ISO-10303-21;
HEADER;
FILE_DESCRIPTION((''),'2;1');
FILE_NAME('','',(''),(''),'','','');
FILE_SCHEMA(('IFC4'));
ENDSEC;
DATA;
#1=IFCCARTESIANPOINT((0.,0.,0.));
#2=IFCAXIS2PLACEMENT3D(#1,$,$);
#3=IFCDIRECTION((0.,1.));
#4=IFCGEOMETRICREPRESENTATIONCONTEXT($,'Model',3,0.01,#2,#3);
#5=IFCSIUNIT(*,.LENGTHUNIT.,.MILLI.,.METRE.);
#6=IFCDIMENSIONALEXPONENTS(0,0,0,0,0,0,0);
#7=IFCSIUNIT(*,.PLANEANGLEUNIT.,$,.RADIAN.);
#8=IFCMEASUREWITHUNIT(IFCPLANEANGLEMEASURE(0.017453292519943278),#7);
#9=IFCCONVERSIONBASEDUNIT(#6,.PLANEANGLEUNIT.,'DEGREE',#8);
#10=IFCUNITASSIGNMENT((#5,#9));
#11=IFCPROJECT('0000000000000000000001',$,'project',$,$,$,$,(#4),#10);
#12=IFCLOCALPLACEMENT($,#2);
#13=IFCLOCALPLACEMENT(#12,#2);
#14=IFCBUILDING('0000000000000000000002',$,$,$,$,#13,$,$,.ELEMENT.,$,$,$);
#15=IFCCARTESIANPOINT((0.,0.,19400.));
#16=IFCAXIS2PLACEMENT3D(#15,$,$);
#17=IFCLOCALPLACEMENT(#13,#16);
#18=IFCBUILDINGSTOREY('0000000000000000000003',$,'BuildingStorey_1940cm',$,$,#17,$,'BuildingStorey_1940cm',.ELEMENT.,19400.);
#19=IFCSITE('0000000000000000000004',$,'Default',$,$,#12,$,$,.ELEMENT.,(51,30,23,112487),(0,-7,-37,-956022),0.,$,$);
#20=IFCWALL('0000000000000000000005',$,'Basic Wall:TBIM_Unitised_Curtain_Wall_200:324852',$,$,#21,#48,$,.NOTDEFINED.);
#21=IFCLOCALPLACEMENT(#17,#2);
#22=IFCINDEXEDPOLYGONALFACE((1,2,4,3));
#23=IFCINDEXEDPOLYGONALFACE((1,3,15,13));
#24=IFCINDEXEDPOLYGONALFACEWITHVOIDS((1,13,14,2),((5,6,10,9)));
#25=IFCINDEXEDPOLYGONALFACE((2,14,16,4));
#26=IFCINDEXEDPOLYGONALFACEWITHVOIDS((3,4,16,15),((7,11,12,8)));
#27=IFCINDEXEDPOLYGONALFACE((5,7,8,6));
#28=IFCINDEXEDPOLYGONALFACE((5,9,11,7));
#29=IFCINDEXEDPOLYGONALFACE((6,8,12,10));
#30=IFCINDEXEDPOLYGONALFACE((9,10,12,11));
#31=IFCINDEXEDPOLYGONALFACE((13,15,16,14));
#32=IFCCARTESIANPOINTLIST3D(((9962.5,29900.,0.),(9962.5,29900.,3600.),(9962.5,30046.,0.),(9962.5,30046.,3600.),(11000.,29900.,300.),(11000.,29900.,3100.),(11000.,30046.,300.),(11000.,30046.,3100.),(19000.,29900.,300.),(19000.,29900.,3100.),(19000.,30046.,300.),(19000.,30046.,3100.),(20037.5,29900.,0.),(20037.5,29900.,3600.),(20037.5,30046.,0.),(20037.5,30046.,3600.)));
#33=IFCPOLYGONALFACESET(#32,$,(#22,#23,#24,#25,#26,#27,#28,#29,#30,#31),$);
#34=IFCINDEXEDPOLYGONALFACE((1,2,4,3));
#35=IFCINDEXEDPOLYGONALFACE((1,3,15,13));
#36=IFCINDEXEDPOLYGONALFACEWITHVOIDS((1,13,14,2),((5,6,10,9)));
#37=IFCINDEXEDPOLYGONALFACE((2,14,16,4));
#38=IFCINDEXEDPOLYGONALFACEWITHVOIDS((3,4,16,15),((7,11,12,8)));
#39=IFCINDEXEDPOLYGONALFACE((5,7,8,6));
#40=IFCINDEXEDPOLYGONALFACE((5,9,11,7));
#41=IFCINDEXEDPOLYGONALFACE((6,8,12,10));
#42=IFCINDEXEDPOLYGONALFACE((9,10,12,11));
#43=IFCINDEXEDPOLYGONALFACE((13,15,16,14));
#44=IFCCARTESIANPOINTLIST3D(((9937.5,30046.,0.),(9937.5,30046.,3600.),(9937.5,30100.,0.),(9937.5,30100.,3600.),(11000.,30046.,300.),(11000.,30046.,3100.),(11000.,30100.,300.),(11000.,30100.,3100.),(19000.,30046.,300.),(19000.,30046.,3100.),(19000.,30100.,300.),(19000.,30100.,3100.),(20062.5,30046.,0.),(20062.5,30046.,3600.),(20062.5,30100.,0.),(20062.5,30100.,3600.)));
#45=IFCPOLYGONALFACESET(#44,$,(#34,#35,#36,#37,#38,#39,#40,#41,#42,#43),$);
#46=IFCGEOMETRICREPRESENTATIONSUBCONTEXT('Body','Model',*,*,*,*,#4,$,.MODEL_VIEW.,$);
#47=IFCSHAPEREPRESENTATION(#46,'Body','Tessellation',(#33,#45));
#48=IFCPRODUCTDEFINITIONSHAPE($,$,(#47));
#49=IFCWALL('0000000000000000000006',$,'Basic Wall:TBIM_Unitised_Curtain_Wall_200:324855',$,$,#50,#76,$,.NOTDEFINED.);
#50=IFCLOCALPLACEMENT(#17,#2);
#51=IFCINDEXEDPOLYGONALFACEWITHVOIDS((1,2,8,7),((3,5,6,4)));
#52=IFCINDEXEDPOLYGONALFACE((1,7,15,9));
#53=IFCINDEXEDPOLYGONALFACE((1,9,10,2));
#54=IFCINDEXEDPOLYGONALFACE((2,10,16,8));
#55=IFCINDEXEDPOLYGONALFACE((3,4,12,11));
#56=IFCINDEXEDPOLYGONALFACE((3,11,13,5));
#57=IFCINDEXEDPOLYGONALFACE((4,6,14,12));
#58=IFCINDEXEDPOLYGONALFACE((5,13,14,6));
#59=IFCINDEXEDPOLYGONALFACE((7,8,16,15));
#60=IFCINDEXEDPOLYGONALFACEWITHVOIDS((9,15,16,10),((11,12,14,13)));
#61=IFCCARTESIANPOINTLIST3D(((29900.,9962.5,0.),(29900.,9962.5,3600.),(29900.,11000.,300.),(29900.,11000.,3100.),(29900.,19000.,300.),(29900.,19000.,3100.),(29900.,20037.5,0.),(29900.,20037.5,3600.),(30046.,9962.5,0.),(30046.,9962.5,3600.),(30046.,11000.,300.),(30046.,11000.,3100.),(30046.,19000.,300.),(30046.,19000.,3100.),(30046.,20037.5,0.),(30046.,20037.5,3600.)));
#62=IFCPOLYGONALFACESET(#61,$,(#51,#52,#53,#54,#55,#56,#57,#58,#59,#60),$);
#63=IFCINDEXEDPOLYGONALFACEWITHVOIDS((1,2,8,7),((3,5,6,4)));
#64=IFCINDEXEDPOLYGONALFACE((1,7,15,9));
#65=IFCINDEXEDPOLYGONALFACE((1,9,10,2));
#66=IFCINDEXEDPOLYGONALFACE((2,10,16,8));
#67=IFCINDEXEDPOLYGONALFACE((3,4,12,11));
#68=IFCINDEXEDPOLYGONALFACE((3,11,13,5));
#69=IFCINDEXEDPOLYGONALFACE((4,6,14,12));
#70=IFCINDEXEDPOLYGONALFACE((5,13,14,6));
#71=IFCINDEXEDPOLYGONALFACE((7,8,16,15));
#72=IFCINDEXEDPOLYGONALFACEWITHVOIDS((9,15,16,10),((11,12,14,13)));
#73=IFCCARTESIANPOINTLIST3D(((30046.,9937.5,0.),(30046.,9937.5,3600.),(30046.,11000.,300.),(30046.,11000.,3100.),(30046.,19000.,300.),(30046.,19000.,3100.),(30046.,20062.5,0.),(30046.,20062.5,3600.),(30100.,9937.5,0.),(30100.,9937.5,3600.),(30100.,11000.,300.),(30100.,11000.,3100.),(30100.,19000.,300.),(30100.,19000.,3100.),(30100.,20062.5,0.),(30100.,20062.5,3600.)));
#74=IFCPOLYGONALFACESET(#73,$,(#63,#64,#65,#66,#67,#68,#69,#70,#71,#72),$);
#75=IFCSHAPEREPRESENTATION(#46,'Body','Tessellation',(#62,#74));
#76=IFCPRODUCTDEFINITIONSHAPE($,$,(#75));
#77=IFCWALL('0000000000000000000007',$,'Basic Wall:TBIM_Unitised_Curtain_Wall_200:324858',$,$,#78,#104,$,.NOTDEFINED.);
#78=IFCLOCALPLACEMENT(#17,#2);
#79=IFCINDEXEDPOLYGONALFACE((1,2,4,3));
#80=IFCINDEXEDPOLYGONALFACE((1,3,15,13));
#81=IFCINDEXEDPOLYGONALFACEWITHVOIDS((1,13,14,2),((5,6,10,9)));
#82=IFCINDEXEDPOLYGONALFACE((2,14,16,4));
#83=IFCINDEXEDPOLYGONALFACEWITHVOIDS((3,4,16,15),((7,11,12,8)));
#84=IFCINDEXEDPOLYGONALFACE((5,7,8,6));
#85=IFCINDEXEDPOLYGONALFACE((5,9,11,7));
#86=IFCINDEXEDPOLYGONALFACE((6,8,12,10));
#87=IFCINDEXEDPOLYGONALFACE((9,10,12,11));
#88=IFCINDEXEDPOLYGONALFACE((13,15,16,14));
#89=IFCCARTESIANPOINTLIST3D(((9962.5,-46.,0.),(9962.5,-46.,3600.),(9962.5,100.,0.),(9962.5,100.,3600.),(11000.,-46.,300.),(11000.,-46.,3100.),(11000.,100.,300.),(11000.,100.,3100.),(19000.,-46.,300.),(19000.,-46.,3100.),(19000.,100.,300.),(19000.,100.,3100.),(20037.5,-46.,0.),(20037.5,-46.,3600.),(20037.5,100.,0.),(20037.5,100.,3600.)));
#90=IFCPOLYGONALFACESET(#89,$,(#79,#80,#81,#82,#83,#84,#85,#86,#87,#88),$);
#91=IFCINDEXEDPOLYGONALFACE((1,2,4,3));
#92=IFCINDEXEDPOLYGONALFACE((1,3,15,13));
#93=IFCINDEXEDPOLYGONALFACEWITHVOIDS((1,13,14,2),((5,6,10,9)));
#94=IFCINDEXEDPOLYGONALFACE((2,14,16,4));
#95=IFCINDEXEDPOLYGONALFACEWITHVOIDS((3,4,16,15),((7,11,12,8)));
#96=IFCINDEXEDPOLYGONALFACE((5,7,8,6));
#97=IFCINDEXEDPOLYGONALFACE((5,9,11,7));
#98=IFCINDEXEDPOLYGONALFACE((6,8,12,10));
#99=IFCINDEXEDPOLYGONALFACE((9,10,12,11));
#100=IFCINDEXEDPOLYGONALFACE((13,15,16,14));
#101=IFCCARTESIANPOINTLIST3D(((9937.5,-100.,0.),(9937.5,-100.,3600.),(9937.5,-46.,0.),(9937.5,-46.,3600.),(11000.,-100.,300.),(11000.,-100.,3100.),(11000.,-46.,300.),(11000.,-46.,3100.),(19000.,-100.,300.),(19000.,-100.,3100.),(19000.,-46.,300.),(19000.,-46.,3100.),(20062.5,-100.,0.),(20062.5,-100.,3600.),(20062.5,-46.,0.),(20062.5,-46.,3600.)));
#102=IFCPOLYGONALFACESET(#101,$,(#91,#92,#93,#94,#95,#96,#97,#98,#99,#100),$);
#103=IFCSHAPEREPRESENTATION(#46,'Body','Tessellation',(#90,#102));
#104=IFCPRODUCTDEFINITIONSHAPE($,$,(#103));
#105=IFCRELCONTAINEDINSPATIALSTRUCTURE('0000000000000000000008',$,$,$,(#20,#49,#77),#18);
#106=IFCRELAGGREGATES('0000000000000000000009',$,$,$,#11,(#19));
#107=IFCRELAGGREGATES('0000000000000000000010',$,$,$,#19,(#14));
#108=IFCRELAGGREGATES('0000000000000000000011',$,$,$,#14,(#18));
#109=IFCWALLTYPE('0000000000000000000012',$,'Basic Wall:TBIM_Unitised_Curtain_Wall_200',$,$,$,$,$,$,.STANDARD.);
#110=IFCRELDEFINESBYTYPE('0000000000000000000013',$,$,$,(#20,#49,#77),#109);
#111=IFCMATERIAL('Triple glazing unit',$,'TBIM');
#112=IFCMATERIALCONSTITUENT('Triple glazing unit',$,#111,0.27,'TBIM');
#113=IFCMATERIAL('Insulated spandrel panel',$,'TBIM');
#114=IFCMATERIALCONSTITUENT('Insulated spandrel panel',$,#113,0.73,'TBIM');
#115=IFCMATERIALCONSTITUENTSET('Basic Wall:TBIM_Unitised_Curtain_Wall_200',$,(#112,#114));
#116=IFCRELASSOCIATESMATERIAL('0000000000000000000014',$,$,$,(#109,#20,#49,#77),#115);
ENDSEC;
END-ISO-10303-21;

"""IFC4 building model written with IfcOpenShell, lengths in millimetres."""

from ifc_helpers import new_model, entity, si_unit, converted_unit, direction, frame, origin, place, context, subcontext, project, spatial, indexed_curve, outline, extrude, material, constituent, constituent_set, type_object, element, save


model = new_model("IFC4")

# Units and contexts
model_context = context("Model", 3, precision=0.01, world=origin(), true_north=direction((0.0, 1.0)))
body_context = subcontext(model_context, "Body", "Model", "MODEL_VIEW")
ifc_project = project(units=[si_unit("LENGTHUNIT", "METRE", prefix="MILLI"), converted_unit("PLANEANGLEUNIT", "DEGREE", entity("IfcPlaneAngleMeasure", 0.017453292519943278), si_unit("PLANEANGLEUNIT", "RADIAN"), dimensions=[0, 0, 0, 0, 0, 0, 0])], contexts=[model_context])

# Site, building, storey
site_placement = place(None, origin())
site = spatial("IfcSite", under=ifc_project, at=site_placement, Name="Default", CompositionType="ELEMENT", RefLatitude=(51, 30, 23, 112487), RefLongitude=(0, -7, -37, -956022), RefElevation=0.0)
building_placement = place(site_placement, origin())
building = spatial("IfcBuilding", under=site, at=building_placement, CompositionType="ELEMENT")
storey_placement = place(building_placement, frame((0.0, 0.0, 19400.0)))
storey = spatial("IfcBuildingStorey", under=building, at=storey_placement, Name="BuildingStorey_1940cm", LongName="BuildingStorey_1940cm", CompositionType="ELEMENT", Elevation=19400.0)

# Walls, openings
ifc_material_1 = material(Name="Triple glazing unit", Category="TBIM")
ifc_constituent_1 = constituent(ifc_material_1, Name="Triple glazing unit", Category="TBIM", fraction=0.27)
ifc_material_2 = material(Name="Insulated spandrel panel", Category="TBIM")
ifc_constituent_2 = constituent(ifc_material_2, Name="Insulated spandrel panel", Category="TBIM", fraction=0.73)
ifc_constituent_set_1 = constituent_set(constituents=[ifc_constituent_1, ifc_constituent_2], Name="Basic Wall:TBIM_Unitised_Curtain_Wall_200")
wall_type_1 = type_object("IfcWallType", Name="Basic Wall:TBIM_Unitised_Curtain_Wall_200", PredefinedType="STANDARD", material=ifc_constituent_set_1)
wall_1_placement = place(storey_placement, frame((9937.5, 30000.0, 0.0)))
wall_1 = element("IfcWall", 1, at=wall_1_placement, inside=storey, type_object=wall_type_1, material=ifc_constituent_set_1, Name="Basic Wall:TBIM_Unitised_Curtain_Wall_200:324852", PredefinedType="NOTDEFINED", context=body_context, shape_type="SweptSolid", body=[
    extrude(outline(indexed_curve([(-1800.0, -5037.5), (1800.0, -5037.5), (1800.0, -4937.5), (1800.0, 4937.5), (1800.0, 5037.5), (-1800.0, 5037.5), (-1800.0, 4937.5), (-1800.0, -4937.5), (-1800.0, -5037.5)], self_intersect=False), holes=[indexed_curve([(1300.0, -4000.0), (-1500.0, -4000.0), (-1500.0, 4000.0), (1300.0, 4000.0), (1300.0, -4000.0)], self_intersect=False)]), frame((5062.5, -100.0, 1800.0), z_axis=(0.0, 1.0, 0.0), x_axis=(0.0, 0.0, 1.0)), (0.0, 0.0, 1.0), 146.0),
    extrude(outline(indexed_curve([(-1800.0, -5062.5), (1800.0, -5062.5), (1800.0, 5062.5), (-1800.0, 5062.5), (-1800.0, -5062.5)], self_intersect=False), holes=[indexed_curve([(-1500.0, -4000.0), (-1500.0, 4000.0), (1300.0, 4000.0), (1300.0, -4000.0), (-1500.0, -4000.0)], self_intersect=False)]), frame((5062.5, 46.0, 1800.0), z_axis=(0.0, 1.0, 0.0), x_axis=(0.0, 0.0, 1.0)), (0.0, 0.0, 1.0), 54.0),
])
opening_1_placement = place(wall_1_placement, frame((1062.5, -100.0, 300.0)))
element("IfcOpeningElement", 2, at=opening_1_placement, cuts=wall_1, PredefinedType="OPENING", context=body_context, shape_type="SweptSolid", body=[
    extrude(outline(indexed_curve([(2800.0, 0.0), (2800.0, 8000.0), (0.0, 8000.0), (0.0, 0.0), (2800.0, 0.0)], self_intersect=False)), frame((0.0, 0.0, 0.0), z_axis=(0.0, 1.0, 0.0), x_axis=(0.0, 0.0, 1.0)), (0.0, 0.0, 1.0), 200.0),
])
wall_2_placement = place(storey_placement, frame((30000.0, 9937.5, 0.0), z_axis=(0.0, 0.0, 1.0), x_axis=(0.0, 1.0, 0.0)))
wall_2 = element("IfcWall", 3, at=wall_2_placement, inside=storey, type_object=wall_type_1, material=ifc_constituent_set_1, Name="Basic Wall:TBIM_Unitised_Curtain_Wall_200:324855", PredefinedType="NOTDEFINED", context=body_context, shape_type="SweptSolid", body=[
    extrude(outline(indexed_curve([(-5037.5, -1800.0), (-4937.5, -1800.0), (4937.5, -1800.0), (5037.5, -1800.0), (5037.5, 1800.0), (4937.5, 1800.0), (-4937.5, 1800.0), (-5037.5, 1800.0), (-5037.5, -1800.0)], self_intersect=False), holes=[indexed_curve([(-4000.0, 1300.0), (4000.0, 1300.0), (4000.0, -1500.0), (-4000.0, -1500.0), (-4000.0, 1300.0)], self_intersect=False)]), frame((5062.5, 100.0, 1800.0), z_axis=(0.0, -1.0, 0.0), x_axis=(1.0, 0.0, 0.0)), (0.0, 0.0, 1.0), 146.0),
    extrude(outline(indexed_curve([(-1800.0, -5062.5), (1800.0, -5062.5), (1800.0, 5062.5), (-1800.0, 5062.5), (-1800.0, -5062.5)], self_intersect=False), holes=[indexed_curve([(1300.0, 4000.0), (1300.0, -4000.0), (-1500.0, -4000.0), (-1500.0, 4000.0), (1300.0, 4000.0)], self_intersect=False)]), frame((5062.5, -46.0, 1800.0), z_axis=(0.0, -1.0, 0.0), x_axis=(0.0, 0.0, 1.0)), (0.0, 0.0, 1.0), 54.0),
])
opening_2_placement = place(wall_2_placement, frame((1062.5, -100.0, 300.0)))
element("IfcOpeningElement", 4, at=opening_2_placement, cuts=wall_2, PredefinedType="OPENING", context=body_context, shape_type="SweptSolid", body=[
    extrude(outline(indexed_curve([(2800.0, 0.0), (2800.0, 8000.0), (0.0, 8000.0), (0.0, 0.0), (2800.0, 0.0)], self_intersect=False)), frame((0.0, 0.0, 0.0), z_axis=(0.0, 1.0, 0.0), x_axis=(0.0, 0.0, 1.0)), (0.0, 0.0, 1.0), 200.0),
])
wall_3_placement = place(storey_placement, frame((9937.5, 0.0, 0.0)))
wall_3 = element("IfcWall", 5, at=wall_3_placement, inside=storey, type_object=wall_type_1, material=ifc_constituent_set_1, Name="Basic Wall:TBIM_Unitised_Curtain_Wall_200:324858", PredefinedType="NOTDEFINED", context=body_context, shape_type="SweptSolid", body=[
    extrude(outline(indexed_curve([(-1800.0, -5037.5), (1800.0, -5037.5), (1800.0, 5037.5), (-1800.0, 5037.5), (-1800.0, -5037.5)], self_intersect=False), holes=[indexed_curve([(-1500.0, -4000.0), (-1500.0, 4000.0), (1300.0, 4000.0), (1300.0, -4000.0), (-1500.0, -4000.0)], self_intersect=False)]), frame((5062.5, -46.0, 1800.0), z_axis=(0.0, 1.0, 0.0), x_axis=(0.0, 0.0, 1.0)), (0.0, 0.0, 1.0), 146.0),
    extrude(outline(indexed_curve([(-1800.0, -5062.5), (1800.0, -5062.5), (1800.0, 5062.5), (-1800.0, 5062.5), (-1800.0, -5062.5)], self_intersect=False), holes=[indexed_curve([(1300.0, -4000.0), (-1500.0, -4000.0), (-1500.0, 4000.0), (1300.0, 4000.0), (1300.0, -4000.0)], self_intersect=False)]), frame((5062.5, -100.0, 1800.0), z_axis=(0.0, 1.0, 0.0), x_axis=(0.0, 0.0, 1.0)), (0.0, 0.0, 1.0), 54.0),
])
opening_3_placement = place(wall_3_placement, frame((1062.5, -100.0, 300.0)))
element("IfcOpeningElement", 6, at=opening_3_placement, cuts=wall_3, PredefinedType="OPENING", context=body_context, shape_type="SweptSolid", body=[
    extrude(outline(indexed_curve([(2800.0, 0.0), (2800.0, 8000.0), (0.0, 8000.0), (0.0, 0.0), (2800.0, 0.0)], self_intersect=False)), frame((0.0, 0.0, 0.0), z_axis=(0.0, 1.0, 0.0), x_axis=(0.0, 0.0, 1.0)), (0.0, 0.0, 1.0), 200.0),
])

save(model, "model.ifc")
